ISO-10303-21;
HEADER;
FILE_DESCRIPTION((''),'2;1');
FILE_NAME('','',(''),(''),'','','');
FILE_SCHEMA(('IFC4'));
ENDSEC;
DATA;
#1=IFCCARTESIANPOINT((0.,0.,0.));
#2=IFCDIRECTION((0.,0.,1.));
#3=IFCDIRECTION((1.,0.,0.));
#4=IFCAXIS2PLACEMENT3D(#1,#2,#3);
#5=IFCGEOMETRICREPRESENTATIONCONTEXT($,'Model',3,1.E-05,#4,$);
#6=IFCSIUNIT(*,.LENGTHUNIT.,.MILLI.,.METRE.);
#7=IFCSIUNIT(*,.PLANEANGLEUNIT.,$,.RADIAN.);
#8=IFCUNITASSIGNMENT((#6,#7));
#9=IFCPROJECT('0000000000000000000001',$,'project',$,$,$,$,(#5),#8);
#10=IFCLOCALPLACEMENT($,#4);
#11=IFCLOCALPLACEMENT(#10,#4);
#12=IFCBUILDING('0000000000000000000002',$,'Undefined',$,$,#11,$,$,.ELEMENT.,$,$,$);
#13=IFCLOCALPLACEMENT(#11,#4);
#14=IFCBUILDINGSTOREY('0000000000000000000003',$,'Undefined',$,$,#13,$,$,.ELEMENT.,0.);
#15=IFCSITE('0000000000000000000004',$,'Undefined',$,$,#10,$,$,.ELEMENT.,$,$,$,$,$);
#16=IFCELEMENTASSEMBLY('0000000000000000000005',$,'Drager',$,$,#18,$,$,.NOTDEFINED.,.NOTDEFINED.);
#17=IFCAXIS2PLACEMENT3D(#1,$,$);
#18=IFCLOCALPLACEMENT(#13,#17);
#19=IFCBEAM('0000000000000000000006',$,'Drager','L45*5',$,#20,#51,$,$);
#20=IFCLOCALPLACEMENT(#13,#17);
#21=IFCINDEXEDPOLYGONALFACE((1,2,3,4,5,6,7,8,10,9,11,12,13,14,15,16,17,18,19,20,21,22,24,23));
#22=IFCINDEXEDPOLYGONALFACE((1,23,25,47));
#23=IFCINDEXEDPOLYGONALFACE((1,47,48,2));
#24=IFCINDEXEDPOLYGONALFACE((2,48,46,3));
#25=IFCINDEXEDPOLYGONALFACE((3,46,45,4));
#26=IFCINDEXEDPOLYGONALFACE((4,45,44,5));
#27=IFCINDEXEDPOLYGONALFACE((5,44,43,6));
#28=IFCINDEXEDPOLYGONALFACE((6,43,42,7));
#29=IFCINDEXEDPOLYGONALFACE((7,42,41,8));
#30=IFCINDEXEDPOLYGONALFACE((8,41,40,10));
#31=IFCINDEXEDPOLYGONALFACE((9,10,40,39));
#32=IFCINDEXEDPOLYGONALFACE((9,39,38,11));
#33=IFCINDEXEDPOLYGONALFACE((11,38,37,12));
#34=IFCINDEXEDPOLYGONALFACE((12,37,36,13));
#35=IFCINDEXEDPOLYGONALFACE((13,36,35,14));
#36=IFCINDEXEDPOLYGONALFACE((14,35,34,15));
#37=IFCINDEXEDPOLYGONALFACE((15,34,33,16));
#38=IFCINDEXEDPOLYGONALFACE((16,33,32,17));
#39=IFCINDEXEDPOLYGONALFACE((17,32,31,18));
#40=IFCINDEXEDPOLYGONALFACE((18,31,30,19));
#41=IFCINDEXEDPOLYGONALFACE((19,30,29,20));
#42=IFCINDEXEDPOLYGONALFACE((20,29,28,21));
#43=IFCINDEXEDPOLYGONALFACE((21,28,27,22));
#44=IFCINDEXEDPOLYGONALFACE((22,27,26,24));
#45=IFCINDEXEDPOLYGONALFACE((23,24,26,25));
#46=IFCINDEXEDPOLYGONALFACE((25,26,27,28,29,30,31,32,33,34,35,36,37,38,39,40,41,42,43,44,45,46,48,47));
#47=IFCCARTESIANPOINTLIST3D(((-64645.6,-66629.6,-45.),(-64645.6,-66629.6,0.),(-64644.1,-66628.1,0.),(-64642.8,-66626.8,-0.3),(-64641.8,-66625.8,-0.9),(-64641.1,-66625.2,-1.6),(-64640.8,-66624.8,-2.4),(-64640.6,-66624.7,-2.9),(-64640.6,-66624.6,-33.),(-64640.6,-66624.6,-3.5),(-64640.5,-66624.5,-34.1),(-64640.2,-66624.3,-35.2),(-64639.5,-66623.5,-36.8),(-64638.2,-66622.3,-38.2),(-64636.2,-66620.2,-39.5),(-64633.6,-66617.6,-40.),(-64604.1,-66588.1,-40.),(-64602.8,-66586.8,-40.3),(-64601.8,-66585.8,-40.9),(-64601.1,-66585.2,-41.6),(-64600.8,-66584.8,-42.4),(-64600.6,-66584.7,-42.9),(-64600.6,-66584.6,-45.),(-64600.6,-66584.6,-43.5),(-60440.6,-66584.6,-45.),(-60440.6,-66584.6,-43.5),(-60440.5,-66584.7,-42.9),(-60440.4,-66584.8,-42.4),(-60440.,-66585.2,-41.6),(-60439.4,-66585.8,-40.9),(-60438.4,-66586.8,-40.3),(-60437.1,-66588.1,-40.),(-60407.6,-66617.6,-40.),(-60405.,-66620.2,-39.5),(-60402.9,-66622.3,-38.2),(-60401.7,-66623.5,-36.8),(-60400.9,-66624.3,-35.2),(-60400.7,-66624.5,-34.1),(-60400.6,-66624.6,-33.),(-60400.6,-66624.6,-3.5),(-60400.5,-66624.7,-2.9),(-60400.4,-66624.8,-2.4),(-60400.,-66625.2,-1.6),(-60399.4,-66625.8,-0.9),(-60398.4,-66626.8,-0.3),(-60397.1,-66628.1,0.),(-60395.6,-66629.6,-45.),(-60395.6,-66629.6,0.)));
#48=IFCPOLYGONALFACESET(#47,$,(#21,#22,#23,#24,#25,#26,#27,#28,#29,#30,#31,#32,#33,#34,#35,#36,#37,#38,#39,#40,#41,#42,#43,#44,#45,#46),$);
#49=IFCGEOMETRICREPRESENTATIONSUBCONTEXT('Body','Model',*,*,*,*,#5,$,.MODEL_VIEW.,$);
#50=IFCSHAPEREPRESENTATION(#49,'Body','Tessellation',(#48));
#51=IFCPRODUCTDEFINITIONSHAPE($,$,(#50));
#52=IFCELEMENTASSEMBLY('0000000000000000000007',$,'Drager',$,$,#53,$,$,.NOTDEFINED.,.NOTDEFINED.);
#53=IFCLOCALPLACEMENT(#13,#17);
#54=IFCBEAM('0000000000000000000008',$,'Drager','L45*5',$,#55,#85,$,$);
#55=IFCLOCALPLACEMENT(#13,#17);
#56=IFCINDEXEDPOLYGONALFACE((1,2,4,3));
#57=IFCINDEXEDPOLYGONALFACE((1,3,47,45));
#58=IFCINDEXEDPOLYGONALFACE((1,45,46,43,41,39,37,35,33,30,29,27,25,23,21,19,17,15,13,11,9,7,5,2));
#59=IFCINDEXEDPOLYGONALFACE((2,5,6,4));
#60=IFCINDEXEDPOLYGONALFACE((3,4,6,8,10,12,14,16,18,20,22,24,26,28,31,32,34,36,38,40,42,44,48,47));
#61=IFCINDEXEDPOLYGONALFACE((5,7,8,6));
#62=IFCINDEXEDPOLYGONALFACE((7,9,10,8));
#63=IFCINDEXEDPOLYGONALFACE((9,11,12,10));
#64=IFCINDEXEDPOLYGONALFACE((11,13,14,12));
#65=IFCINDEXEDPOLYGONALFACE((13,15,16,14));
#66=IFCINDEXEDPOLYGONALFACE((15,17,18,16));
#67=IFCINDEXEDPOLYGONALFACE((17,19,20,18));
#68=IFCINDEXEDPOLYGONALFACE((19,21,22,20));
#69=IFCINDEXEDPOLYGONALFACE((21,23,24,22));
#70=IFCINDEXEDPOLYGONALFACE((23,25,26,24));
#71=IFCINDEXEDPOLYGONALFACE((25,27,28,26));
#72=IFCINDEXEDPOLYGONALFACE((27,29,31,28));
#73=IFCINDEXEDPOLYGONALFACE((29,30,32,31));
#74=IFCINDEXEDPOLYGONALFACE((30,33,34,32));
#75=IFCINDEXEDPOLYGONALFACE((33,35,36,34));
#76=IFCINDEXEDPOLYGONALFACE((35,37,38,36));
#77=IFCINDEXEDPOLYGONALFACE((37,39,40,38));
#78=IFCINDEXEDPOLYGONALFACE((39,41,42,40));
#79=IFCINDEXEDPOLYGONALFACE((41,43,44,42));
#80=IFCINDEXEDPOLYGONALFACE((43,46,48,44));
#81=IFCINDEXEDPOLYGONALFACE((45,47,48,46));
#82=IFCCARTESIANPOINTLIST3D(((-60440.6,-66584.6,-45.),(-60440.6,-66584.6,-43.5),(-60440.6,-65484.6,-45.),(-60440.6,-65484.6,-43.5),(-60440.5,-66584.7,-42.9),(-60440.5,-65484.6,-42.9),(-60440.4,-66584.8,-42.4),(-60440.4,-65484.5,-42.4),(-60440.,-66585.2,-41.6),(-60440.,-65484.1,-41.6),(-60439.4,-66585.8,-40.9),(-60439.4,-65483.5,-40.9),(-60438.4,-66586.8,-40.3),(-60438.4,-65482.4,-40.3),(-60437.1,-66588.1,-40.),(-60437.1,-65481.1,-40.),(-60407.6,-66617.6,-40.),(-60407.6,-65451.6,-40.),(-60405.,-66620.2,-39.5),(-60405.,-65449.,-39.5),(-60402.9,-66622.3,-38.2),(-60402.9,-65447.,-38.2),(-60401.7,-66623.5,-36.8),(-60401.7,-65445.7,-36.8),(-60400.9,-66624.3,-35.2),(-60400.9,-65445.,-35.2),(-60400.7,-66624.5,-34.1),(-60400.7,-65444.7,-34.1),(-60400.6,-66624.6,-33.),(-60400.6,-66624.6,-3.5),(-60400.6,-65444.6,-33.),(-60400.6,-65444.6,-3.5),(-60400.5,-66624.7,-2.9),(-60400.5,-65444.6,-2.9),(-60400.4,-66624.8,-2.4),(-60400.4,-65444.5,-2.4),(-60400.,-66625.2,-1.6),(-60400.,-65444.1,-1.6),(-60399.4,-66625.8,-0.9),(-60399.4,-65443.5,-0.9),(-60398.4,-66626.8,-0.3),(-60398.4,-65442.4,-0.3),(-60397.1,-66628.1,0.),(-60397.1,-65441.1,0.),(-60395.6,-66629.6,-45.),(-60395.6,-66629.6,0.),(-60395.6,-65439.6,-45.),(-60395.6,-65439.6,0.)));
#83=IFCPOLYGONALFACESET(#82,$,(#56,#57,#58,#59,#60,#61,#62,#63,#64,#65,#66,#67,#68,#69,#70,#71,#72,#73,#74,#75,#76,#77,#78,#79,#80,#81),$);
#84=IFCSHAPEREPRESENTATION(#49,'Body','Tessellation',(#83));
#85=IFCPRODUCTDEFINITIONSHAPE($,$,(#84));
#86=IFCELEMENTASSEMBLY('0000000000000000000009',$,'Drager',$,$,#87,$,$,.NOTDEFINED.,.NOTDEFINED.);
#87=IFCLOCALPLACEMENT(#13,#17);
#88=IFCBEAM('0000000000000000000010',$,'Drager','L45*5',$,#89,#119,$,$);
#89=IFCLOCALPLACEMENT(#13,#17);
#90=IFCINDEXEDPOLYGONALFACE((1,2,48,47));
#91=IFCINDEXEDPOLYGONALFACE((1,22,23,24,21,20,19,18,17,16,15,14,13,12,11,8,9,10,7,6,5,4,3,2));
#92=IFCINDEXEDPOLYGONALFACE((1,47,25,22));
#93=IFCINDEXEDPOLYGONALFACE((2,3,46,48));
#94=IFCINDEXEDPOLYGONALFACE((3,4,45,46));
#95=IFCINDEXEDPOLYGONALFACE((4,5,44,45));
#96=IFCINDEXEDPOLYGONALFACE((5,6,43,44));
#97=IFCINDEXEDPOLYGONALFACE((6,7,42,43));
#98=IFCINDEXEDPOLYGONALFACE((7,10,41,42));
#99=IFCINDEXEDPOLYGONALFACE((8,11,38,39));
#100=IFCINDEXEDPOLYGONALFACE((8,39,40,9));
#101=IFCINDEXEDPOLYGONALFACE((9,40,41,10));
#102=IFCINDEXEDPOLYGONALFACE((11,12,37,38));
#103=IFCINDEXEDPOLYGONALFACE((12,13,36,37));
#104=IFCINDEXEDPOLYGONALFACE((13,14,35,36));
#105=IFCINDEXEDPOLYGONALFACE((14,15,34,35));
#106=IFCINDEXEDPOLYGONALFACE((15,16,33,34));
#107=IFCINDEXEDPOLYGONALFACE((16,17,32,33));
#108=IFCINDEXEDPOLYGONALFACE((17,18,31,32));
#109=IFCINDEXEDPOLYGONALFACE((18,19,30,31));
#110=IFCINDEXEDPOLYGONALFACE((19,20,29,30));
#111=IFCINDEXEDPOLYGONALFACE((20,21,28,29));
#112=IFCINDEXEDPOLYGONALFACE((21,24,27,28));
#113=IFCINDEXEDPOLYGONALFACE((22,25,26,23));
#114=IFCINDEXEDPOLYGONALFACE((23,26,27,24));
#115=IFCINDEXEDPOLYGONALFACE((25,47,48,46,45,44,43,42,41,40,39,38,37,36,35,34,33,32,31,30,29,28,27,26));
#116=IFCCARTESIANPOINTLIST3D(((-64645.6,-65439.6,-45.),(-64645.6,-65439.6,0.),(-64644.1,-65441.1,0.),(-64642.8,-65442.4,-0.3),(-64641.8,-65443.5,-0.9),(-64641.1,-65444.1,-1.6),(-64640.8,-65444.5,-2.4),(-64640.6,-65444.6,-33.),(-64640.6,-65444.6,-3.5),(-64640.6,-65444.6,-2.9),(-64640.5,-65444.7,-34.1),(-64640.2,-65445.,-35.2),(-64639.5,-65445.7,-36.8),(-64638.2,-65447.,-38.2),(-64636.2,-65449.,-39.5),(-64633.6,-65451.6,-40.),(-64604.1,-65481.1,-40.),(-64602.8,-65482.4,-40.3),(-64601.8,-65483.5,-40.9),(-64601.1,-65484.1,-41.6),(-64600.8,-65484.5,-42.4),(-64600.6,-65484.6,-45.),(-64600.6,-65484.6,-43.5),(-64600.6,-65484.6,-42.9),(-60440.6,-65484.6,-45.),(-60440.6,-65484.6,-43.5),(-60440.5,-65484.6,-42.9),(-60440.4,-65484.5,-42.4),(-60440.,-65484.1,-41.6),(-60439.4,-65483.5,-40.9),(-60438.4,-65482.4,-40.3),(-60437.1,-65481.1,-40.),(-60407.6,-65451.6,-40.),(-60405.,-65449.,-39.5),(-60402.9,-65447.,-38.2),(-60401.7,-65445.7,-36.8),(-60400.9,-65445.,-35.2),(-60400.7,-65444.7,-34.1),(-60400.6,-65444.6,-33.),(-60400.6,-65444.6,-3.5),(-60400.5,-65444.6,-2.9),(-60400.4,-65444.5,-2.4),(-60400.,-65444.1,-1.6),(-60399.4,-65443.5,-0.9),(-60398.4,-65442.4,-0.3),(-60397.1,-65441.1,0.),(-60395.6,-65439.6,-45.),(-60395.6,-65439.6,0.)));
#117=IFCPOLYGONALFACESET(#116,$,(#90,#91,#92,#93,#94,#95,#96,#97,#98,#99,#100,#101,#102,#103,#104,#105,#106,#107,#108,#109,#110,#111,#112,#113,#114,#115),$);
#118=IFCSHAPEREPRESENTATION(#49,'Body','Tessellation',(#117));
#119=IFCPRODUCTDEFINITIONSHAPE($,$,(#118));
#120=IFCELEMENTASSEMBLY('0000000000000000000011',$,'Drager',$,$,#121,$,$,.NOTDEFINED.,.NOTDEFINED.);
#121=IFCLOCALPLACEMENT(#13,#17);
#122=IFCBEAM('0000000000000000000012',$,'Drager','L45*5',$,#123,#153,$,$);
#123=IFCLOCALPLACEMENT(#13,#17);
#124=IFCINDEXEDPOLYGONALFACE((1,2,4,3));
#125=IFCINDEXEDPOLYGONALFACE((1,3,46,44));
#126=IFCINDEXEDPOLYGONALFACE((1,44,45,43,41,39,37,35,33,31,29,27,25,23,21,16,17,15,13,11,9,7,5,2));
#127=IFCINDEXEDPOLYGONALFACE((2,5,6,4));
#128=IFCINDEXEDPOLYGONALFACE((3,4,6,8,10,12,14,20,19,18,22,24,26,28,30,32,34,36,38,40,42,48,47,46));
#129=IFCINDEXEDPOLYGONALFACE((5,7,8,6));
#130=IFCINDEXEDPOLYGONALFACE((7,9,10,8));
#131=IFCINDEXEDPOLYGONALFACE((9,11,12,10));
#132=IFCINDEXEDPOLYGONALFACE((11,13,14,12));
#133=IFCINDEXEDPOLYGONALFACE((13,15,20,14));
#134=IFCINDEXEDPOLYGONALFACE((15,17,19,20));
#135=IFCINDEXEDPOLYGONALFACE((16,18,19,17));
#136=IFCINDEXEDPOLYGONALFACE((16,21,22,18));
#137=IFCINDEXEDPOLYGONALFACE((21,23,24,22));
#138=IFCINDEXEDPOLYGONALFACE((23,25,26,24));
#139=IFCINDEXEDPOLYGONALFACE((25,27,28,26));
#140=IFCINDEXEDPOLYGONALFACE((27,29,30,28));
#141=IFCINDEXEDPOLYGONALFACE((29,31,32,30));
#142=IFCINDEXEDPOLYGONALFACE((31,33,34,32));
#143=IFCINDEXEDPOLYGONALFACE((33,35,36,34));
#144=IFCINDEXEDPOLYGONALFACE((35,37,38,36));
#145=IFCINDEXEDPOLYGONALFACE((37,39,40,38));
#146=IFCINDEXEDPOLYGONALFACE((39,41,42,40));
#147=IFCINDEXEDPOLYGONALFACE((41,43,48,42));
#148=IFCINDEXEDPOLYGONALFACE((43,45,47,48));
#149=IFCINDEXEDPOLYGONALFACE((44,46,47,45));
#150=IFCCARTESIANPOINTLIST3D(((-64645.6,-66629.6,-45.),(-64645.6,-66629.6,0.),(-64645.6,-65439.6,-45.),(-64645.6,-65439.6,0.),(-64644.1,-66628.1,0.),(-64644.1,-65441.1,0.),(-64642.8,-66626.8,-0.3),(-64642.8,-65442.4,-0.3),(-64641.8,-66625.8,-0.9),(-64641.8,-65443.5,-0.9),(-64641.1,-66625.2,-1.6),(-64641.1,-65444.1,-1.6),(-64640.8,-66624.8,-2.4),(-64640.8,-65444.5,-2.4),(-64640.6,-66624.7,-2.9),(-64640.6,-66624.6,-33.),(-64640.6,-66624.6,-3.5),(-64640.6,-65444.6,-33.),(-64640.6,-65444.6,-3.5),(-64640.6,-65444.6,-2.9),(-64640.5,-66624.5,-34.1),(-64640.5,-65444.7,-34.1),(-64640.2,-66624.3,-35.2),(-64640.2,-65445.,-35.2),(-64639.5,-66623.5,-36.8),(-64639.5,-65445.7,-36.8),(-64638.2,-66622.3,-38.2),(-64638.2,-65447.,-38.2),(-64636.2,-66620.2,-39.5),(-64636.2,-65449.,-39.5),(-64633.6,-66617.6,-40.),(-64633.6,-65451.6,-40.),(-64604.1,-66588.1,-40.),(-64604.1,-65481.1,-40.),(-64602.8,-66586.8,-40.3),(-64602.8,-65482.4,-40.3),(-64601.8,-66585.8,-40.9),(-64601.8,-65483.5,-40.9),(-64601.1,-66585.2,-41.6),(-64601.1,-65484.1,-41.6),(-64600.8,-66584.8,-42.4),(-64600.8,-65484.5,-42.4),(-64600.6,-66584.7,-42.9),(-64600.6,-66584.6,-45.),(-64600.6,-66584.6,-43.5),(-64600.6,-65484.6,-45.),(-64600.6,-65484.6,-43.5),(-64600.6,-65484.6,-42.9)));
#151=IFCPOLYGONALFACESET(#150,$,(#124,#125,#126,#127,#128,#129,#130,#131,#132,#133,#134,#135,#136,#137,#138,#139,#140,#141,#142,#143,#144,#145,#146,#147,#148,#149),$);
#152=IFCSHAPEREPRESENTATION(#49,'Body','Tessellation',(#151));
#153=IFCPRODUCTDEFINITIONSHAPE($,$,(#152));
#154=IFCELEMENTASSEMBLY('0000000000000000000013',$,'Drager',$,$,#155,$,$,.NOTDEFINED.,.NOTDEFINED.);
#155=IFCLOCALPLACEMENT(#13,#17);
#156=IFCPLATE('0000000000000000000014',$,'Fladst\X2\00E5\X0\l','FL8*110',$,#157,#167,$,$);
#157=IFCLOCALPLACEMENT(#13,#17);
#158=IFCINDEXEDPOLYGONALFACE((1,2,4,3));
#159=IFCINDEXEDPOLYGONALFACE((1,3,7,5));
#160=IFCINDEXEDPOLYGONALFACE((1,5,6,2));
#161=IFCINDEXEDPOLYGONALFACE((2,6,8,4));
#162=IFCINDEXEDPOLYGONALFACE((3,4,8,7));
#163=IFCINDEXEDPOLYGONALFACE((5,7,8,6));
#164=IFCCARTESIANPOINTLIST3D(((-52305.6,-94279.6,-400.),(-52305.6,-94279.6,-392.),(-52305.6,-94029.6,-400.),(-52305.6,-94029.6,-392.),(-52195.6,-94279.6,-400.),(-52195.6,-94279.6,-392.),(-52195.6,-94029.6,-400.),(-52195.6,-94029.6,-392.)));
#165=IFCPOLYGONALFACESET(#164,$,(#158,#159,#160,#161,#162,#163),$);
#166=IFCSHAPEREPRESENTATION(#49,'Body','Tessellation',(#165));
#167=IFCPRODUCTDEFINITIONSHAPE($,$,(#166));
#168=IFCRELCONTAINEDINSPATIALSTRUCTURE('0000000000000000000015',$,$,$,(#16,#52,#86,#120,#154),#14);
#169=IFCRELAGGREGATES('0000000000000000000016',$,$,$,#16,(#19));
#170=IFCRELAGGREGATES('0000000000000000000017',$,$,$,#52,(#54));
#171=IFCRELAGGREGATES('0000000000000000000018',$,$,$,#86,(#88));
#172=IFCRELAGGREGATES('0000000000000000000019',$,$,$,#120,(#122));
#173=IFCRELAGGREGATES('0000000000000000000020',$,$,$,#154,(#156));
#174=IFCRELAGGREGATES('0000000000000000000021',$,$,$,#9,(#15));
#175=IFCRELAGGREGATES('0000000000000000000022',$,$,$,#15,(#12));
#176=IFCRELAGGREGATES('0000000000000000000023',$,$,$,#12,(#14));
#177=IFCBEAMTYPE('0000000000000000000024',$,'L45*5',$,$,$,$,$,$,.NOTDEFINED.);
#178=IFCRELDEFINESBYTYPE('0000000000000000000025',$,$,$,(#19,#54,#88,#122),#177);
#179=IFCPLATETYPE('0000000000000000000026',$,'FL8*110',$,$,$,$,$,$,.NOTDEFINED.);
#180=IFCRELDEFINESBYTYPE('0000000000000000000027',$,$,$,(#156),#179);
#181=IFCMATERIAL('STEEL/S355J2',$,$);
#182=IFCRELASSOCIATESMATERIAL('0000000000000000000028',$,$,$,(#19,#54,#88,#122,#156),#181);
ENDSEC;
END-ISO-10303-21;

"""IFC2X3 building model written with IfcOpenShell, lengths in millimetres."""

from ifc_helpers import new_model, si_unit, frame, origin_with_axes, origin_2d_with_axis, place, context, subcontext, project, spatial, polyline, l_section, outline, extrude, clip, halfspace, material, type_object, element, aggregate, save


model = new_model("IFC2X3")

# Units and contexts
model_context = context("Model", 3, precision=1e-05, world=origin_with_axes())
body_context = subcontext(model_context, "Body", "Model", "MODEL_VIEW")
ifc_project = project(units=[si_unit("LENGTHUNIT", "METRE", prefix="MILLI"), si_unit("PLANEANGLEUNIT", "RADIAN")], contexts=[model_context])

# Site, building, storey
site_placement = place(None, origin_with_axes())
site = spatial("IfcSite", under=ifc_project, at=site_placement, Name="Undefined", CompositionType="ELEMENT")
building_placement = place(site_placement, origin_with_axes())
building = spatial("IfcBuilding", under=site, at=building_placement, Name="Undefined", CompositionType="ELEMENT")
storey_placement = place(building_placement, origin_with_axes())
storey = spatial("IfcBuildingStorey", under=building, at=storey_placement, Name="Undefined", CompositionType="ELEMENT", Elevation=0.0)

# Shared definitions
ifc_material_1 = material(Name="STEEL/S355J2")

# Element assemblies, beams
beam_type_1 = type_object("IfcBeamType", Name="L45*5", PredefinedType="NOTDEFINED")
assembly_1_placement = place(storey_placement, origin_with_axes())
assembly_1 = element("IfcElementAssembly", 1, at=assembly_1_placement, inside=storey, Name="Drager", AssemblyPlace="NOTDEFINED", PredefinedType="NOTDEFINED")
beam_1_placement = place(assembly_1_placement, frame((-60440.6, -66607.1, -22.5), z_axis=(0.0, 0.0, 1.0), x_axis=(-1.0, 0.0, 0.0)))
beam_1 = element("IfcBeam", 2, at=beam_1_placement, type_object=beam_type_1, material=ifc_material_1, Name="Drager", Description="L45*5", context=body_context, shape_type="Clipping", body=[
    clip(clip(extrude(l_section(Depth=45.0, Width=45.0, Thickness=5.0, FilletRadius=7.0, EdgeRadius=3.5, at=origin_2d_with_axis()), frame((4227.9, 0.0, 0.0), z_axis=(-1.0, 0.0, 0.0), x_axis=(0.0, -1.0, 0.0)), (0.0, 0.0, 1.0), 4295.9), halfspace(frame((4160.0, -22.5, 22.5), z_axis=(0.707107, -0.707107, 0.0), x_axis=(0.0, 0.0, 1.0)), False)), halfspace(frame((0.0, -22.5, 22.5), z_axis=(0.707107, 0.707107, 0.0), x_axis=(0.0, 0.0, 1.0)), True)),
])
aggregate(assembly_1, [beam_1])
assembly_2_placement = place(storey_placement, origin_with_axes())
assembly_2 = element("IfcElementAssembly", 3, at=assembly_2_placement, inside=storey, Name="Drager", AssemblyPlace="NOTDEFINED", PredefinedType="NOTDEFINED")
beam_2_placement = place(assembly_2_placement, frame((-60418.1, -65484.6, -22.5), z_axis=(0.0, 0.0, 1.0), x_axis=(0.0, -1.0, 0.0)))
beam_2 = element("IfcBeam", 4, at=beam_2_placement, type_object=beam_type_1, material=ifc_material_1, Name="Drager", Description="L45*5", context=body_context, shape_type="Clipping", body=[
    clip(clip(extrude(l_section(Depth=45.0, Width=45.0, Thickness=5.0, FilletRadius=7.0, EdgeRadius=3.5, at=origin_2d_with_axis()), frame((1167.9, 0.0, 0.0), z_axis=(-1.0, 0.0, 0.0), x_axis=(0.0, -1.0, 0.0)), (0.0, 0.0, 1.0), 1235.9), halfspace(frame((1100.0, -22.5, 22.5), z_axis=(0.707107, -0.707107, 0.0), x_axis=(0.0, 0.0, 1.0)), False)), halfspace(frame((0.0, -22.5, 22.5), z_axis=(0.707107, 0.707107, 0.0), x_axis=(0.0, 0.0, 1.0)), True)),
])
aggregate(assembly_2, [beam_2])
assembly_3_placement = place(storey_placement, origin_with_axes())
assembly_3 = element("IfcElementAssembly", 5, at=assembly_3_placement, inside=storey, Name="Drager", AssemblyPlace="NOTDEFINED", PredefinedType="NOTDEFINED")
beam_3_placement = place(assembly_3_placement, frame((-64600.6, -65462.1, -22.5), z_axis=(0.0, 0.0, 1.0), x_axis=(1.0, 0.0, 0.0)))
beam_3 = element("IfcBeam", 6, at=beam_3_placement, type_object=beam_type_1, material=ifc_material_1, Name="Drager", Description="L45*5", context=body_context, shape_type="Clipping", body=[
    clip(clip(extrude(l_section(Depth=45.0, Width=45.0, Thickness=5.0, FilletRadius=7.0, EdgeRadius=3.5, at=origin_2d_with_axis()), frame((4227.9, 0.0, 0.0), z_axis=(-1.0, 0.0, 0.0), x_axis=(0.0, -1.0, 0.0)), (0.0, 0.0, 1.0), 4295.9), halfspace(frame((4160.0, -22.5, 22.5), z_axis=(0.707107, -0.707107, 0.0), x_axis=(0.0, 0.0, 1.0)), False)), halfspace(frame((0.0, -22.5, 22.5), z_axis=(0.707107, 0.707107, 0.0), x_axis=(0.0, 0.0, 1.0)), True)),
])
aggregate(assembly_3, [beam_3])
assembly_4_placement = place(storey_placement, origin_with_axes())
assembly_4 = element("IfcElementAssembly", 7, at=assembly_4_placement, inside=storey, Name="Drager", AssemblyPlace="NOTDEFINED", PredefinedType="NOTDEFINED")
beam_4_placement = place(assembly_4_placement, frame((-64623.1, -66584.6, -22.5), z_axis=(0.0, 0.0, 1.0), x_axis=(0.0, 1.0, 0.0)))
beam_4 = element("IfcBeam", 8, at=beam_4_placement, type_object=beam_type_1, material=ifc_material_1, Name="Drager", Description="L45*5", context=body_context, shape_type="Clipping", body=[
    clip(clip(extrude(l_section(Depth=45.0, Width=45.0, Thickness=5.0, FilletRadius=7.0, EdgeRadius=3.5, at=origin_2d_with_axis()), frame((1167.9, 0.0, 0.0), z_axis=(-1.0, 0.0, 0.0), x_axis=(0.0, -1.0, 0.0)), (0.0, 0.0, 1.0), 1235.9), halfspace(frame((1100.0, -22.5, 22.5), z_axis=(0.707107, -0.707107, 0.0), x_axis=(0.0, 0.0, 1.0)), False)), halfspace(frame((0.0, -22.5, 22.5), z_axis=(0.707107, 0.707107, 0.0), x_axis=(0.0, 0.0, 1.0)), True)),
])
aggregate(assembly_4, [beam_4])

# Element assembly, plate
assembly_5_placement = place(storey_placement, origin_with_axes())
assembly_5 = element("IfcElementAssembly", 9, at=assembly_5_placement, inside=storey, Name="Drager", AssemblyPlace="NOTDEFINED", PredefinedType="NOTDEFINED")
plate_type = type_object("IfcPlateType", Name="FL8*110", PredefinedType="NOTDEFINED")
plate_placement = place(assembly_5_placement, frame((-52305.6, -94154.6, -396.0), z_axis=(0.0, 0.0, 1.0), x_axis=(1.0, 0.0, 0.0)))
plate = element("IfcPlate", 10, at=plate_placement, type_object=plate_type, material=ifc_material_1, Name="Fladstål", Description="FL8*110", context=body_context, shape_type="SweptSolid", body=[
    extrude(outline(polyline([(0.0, -125.0), (0.0, 125.0), (110.0, 125.0), (110.0, -125.0), (0.0, -125.0)])), frame((0.0, 0.0, -4.0), z_axis=(0.0, 0.0, 1.0), x_axis=(1.0, 0.0, 0.0)), (0.0, 0.0, 1.0), 8.0),
])
aggregate(assembly_5, [plate])

save(model, "model.ifc")
